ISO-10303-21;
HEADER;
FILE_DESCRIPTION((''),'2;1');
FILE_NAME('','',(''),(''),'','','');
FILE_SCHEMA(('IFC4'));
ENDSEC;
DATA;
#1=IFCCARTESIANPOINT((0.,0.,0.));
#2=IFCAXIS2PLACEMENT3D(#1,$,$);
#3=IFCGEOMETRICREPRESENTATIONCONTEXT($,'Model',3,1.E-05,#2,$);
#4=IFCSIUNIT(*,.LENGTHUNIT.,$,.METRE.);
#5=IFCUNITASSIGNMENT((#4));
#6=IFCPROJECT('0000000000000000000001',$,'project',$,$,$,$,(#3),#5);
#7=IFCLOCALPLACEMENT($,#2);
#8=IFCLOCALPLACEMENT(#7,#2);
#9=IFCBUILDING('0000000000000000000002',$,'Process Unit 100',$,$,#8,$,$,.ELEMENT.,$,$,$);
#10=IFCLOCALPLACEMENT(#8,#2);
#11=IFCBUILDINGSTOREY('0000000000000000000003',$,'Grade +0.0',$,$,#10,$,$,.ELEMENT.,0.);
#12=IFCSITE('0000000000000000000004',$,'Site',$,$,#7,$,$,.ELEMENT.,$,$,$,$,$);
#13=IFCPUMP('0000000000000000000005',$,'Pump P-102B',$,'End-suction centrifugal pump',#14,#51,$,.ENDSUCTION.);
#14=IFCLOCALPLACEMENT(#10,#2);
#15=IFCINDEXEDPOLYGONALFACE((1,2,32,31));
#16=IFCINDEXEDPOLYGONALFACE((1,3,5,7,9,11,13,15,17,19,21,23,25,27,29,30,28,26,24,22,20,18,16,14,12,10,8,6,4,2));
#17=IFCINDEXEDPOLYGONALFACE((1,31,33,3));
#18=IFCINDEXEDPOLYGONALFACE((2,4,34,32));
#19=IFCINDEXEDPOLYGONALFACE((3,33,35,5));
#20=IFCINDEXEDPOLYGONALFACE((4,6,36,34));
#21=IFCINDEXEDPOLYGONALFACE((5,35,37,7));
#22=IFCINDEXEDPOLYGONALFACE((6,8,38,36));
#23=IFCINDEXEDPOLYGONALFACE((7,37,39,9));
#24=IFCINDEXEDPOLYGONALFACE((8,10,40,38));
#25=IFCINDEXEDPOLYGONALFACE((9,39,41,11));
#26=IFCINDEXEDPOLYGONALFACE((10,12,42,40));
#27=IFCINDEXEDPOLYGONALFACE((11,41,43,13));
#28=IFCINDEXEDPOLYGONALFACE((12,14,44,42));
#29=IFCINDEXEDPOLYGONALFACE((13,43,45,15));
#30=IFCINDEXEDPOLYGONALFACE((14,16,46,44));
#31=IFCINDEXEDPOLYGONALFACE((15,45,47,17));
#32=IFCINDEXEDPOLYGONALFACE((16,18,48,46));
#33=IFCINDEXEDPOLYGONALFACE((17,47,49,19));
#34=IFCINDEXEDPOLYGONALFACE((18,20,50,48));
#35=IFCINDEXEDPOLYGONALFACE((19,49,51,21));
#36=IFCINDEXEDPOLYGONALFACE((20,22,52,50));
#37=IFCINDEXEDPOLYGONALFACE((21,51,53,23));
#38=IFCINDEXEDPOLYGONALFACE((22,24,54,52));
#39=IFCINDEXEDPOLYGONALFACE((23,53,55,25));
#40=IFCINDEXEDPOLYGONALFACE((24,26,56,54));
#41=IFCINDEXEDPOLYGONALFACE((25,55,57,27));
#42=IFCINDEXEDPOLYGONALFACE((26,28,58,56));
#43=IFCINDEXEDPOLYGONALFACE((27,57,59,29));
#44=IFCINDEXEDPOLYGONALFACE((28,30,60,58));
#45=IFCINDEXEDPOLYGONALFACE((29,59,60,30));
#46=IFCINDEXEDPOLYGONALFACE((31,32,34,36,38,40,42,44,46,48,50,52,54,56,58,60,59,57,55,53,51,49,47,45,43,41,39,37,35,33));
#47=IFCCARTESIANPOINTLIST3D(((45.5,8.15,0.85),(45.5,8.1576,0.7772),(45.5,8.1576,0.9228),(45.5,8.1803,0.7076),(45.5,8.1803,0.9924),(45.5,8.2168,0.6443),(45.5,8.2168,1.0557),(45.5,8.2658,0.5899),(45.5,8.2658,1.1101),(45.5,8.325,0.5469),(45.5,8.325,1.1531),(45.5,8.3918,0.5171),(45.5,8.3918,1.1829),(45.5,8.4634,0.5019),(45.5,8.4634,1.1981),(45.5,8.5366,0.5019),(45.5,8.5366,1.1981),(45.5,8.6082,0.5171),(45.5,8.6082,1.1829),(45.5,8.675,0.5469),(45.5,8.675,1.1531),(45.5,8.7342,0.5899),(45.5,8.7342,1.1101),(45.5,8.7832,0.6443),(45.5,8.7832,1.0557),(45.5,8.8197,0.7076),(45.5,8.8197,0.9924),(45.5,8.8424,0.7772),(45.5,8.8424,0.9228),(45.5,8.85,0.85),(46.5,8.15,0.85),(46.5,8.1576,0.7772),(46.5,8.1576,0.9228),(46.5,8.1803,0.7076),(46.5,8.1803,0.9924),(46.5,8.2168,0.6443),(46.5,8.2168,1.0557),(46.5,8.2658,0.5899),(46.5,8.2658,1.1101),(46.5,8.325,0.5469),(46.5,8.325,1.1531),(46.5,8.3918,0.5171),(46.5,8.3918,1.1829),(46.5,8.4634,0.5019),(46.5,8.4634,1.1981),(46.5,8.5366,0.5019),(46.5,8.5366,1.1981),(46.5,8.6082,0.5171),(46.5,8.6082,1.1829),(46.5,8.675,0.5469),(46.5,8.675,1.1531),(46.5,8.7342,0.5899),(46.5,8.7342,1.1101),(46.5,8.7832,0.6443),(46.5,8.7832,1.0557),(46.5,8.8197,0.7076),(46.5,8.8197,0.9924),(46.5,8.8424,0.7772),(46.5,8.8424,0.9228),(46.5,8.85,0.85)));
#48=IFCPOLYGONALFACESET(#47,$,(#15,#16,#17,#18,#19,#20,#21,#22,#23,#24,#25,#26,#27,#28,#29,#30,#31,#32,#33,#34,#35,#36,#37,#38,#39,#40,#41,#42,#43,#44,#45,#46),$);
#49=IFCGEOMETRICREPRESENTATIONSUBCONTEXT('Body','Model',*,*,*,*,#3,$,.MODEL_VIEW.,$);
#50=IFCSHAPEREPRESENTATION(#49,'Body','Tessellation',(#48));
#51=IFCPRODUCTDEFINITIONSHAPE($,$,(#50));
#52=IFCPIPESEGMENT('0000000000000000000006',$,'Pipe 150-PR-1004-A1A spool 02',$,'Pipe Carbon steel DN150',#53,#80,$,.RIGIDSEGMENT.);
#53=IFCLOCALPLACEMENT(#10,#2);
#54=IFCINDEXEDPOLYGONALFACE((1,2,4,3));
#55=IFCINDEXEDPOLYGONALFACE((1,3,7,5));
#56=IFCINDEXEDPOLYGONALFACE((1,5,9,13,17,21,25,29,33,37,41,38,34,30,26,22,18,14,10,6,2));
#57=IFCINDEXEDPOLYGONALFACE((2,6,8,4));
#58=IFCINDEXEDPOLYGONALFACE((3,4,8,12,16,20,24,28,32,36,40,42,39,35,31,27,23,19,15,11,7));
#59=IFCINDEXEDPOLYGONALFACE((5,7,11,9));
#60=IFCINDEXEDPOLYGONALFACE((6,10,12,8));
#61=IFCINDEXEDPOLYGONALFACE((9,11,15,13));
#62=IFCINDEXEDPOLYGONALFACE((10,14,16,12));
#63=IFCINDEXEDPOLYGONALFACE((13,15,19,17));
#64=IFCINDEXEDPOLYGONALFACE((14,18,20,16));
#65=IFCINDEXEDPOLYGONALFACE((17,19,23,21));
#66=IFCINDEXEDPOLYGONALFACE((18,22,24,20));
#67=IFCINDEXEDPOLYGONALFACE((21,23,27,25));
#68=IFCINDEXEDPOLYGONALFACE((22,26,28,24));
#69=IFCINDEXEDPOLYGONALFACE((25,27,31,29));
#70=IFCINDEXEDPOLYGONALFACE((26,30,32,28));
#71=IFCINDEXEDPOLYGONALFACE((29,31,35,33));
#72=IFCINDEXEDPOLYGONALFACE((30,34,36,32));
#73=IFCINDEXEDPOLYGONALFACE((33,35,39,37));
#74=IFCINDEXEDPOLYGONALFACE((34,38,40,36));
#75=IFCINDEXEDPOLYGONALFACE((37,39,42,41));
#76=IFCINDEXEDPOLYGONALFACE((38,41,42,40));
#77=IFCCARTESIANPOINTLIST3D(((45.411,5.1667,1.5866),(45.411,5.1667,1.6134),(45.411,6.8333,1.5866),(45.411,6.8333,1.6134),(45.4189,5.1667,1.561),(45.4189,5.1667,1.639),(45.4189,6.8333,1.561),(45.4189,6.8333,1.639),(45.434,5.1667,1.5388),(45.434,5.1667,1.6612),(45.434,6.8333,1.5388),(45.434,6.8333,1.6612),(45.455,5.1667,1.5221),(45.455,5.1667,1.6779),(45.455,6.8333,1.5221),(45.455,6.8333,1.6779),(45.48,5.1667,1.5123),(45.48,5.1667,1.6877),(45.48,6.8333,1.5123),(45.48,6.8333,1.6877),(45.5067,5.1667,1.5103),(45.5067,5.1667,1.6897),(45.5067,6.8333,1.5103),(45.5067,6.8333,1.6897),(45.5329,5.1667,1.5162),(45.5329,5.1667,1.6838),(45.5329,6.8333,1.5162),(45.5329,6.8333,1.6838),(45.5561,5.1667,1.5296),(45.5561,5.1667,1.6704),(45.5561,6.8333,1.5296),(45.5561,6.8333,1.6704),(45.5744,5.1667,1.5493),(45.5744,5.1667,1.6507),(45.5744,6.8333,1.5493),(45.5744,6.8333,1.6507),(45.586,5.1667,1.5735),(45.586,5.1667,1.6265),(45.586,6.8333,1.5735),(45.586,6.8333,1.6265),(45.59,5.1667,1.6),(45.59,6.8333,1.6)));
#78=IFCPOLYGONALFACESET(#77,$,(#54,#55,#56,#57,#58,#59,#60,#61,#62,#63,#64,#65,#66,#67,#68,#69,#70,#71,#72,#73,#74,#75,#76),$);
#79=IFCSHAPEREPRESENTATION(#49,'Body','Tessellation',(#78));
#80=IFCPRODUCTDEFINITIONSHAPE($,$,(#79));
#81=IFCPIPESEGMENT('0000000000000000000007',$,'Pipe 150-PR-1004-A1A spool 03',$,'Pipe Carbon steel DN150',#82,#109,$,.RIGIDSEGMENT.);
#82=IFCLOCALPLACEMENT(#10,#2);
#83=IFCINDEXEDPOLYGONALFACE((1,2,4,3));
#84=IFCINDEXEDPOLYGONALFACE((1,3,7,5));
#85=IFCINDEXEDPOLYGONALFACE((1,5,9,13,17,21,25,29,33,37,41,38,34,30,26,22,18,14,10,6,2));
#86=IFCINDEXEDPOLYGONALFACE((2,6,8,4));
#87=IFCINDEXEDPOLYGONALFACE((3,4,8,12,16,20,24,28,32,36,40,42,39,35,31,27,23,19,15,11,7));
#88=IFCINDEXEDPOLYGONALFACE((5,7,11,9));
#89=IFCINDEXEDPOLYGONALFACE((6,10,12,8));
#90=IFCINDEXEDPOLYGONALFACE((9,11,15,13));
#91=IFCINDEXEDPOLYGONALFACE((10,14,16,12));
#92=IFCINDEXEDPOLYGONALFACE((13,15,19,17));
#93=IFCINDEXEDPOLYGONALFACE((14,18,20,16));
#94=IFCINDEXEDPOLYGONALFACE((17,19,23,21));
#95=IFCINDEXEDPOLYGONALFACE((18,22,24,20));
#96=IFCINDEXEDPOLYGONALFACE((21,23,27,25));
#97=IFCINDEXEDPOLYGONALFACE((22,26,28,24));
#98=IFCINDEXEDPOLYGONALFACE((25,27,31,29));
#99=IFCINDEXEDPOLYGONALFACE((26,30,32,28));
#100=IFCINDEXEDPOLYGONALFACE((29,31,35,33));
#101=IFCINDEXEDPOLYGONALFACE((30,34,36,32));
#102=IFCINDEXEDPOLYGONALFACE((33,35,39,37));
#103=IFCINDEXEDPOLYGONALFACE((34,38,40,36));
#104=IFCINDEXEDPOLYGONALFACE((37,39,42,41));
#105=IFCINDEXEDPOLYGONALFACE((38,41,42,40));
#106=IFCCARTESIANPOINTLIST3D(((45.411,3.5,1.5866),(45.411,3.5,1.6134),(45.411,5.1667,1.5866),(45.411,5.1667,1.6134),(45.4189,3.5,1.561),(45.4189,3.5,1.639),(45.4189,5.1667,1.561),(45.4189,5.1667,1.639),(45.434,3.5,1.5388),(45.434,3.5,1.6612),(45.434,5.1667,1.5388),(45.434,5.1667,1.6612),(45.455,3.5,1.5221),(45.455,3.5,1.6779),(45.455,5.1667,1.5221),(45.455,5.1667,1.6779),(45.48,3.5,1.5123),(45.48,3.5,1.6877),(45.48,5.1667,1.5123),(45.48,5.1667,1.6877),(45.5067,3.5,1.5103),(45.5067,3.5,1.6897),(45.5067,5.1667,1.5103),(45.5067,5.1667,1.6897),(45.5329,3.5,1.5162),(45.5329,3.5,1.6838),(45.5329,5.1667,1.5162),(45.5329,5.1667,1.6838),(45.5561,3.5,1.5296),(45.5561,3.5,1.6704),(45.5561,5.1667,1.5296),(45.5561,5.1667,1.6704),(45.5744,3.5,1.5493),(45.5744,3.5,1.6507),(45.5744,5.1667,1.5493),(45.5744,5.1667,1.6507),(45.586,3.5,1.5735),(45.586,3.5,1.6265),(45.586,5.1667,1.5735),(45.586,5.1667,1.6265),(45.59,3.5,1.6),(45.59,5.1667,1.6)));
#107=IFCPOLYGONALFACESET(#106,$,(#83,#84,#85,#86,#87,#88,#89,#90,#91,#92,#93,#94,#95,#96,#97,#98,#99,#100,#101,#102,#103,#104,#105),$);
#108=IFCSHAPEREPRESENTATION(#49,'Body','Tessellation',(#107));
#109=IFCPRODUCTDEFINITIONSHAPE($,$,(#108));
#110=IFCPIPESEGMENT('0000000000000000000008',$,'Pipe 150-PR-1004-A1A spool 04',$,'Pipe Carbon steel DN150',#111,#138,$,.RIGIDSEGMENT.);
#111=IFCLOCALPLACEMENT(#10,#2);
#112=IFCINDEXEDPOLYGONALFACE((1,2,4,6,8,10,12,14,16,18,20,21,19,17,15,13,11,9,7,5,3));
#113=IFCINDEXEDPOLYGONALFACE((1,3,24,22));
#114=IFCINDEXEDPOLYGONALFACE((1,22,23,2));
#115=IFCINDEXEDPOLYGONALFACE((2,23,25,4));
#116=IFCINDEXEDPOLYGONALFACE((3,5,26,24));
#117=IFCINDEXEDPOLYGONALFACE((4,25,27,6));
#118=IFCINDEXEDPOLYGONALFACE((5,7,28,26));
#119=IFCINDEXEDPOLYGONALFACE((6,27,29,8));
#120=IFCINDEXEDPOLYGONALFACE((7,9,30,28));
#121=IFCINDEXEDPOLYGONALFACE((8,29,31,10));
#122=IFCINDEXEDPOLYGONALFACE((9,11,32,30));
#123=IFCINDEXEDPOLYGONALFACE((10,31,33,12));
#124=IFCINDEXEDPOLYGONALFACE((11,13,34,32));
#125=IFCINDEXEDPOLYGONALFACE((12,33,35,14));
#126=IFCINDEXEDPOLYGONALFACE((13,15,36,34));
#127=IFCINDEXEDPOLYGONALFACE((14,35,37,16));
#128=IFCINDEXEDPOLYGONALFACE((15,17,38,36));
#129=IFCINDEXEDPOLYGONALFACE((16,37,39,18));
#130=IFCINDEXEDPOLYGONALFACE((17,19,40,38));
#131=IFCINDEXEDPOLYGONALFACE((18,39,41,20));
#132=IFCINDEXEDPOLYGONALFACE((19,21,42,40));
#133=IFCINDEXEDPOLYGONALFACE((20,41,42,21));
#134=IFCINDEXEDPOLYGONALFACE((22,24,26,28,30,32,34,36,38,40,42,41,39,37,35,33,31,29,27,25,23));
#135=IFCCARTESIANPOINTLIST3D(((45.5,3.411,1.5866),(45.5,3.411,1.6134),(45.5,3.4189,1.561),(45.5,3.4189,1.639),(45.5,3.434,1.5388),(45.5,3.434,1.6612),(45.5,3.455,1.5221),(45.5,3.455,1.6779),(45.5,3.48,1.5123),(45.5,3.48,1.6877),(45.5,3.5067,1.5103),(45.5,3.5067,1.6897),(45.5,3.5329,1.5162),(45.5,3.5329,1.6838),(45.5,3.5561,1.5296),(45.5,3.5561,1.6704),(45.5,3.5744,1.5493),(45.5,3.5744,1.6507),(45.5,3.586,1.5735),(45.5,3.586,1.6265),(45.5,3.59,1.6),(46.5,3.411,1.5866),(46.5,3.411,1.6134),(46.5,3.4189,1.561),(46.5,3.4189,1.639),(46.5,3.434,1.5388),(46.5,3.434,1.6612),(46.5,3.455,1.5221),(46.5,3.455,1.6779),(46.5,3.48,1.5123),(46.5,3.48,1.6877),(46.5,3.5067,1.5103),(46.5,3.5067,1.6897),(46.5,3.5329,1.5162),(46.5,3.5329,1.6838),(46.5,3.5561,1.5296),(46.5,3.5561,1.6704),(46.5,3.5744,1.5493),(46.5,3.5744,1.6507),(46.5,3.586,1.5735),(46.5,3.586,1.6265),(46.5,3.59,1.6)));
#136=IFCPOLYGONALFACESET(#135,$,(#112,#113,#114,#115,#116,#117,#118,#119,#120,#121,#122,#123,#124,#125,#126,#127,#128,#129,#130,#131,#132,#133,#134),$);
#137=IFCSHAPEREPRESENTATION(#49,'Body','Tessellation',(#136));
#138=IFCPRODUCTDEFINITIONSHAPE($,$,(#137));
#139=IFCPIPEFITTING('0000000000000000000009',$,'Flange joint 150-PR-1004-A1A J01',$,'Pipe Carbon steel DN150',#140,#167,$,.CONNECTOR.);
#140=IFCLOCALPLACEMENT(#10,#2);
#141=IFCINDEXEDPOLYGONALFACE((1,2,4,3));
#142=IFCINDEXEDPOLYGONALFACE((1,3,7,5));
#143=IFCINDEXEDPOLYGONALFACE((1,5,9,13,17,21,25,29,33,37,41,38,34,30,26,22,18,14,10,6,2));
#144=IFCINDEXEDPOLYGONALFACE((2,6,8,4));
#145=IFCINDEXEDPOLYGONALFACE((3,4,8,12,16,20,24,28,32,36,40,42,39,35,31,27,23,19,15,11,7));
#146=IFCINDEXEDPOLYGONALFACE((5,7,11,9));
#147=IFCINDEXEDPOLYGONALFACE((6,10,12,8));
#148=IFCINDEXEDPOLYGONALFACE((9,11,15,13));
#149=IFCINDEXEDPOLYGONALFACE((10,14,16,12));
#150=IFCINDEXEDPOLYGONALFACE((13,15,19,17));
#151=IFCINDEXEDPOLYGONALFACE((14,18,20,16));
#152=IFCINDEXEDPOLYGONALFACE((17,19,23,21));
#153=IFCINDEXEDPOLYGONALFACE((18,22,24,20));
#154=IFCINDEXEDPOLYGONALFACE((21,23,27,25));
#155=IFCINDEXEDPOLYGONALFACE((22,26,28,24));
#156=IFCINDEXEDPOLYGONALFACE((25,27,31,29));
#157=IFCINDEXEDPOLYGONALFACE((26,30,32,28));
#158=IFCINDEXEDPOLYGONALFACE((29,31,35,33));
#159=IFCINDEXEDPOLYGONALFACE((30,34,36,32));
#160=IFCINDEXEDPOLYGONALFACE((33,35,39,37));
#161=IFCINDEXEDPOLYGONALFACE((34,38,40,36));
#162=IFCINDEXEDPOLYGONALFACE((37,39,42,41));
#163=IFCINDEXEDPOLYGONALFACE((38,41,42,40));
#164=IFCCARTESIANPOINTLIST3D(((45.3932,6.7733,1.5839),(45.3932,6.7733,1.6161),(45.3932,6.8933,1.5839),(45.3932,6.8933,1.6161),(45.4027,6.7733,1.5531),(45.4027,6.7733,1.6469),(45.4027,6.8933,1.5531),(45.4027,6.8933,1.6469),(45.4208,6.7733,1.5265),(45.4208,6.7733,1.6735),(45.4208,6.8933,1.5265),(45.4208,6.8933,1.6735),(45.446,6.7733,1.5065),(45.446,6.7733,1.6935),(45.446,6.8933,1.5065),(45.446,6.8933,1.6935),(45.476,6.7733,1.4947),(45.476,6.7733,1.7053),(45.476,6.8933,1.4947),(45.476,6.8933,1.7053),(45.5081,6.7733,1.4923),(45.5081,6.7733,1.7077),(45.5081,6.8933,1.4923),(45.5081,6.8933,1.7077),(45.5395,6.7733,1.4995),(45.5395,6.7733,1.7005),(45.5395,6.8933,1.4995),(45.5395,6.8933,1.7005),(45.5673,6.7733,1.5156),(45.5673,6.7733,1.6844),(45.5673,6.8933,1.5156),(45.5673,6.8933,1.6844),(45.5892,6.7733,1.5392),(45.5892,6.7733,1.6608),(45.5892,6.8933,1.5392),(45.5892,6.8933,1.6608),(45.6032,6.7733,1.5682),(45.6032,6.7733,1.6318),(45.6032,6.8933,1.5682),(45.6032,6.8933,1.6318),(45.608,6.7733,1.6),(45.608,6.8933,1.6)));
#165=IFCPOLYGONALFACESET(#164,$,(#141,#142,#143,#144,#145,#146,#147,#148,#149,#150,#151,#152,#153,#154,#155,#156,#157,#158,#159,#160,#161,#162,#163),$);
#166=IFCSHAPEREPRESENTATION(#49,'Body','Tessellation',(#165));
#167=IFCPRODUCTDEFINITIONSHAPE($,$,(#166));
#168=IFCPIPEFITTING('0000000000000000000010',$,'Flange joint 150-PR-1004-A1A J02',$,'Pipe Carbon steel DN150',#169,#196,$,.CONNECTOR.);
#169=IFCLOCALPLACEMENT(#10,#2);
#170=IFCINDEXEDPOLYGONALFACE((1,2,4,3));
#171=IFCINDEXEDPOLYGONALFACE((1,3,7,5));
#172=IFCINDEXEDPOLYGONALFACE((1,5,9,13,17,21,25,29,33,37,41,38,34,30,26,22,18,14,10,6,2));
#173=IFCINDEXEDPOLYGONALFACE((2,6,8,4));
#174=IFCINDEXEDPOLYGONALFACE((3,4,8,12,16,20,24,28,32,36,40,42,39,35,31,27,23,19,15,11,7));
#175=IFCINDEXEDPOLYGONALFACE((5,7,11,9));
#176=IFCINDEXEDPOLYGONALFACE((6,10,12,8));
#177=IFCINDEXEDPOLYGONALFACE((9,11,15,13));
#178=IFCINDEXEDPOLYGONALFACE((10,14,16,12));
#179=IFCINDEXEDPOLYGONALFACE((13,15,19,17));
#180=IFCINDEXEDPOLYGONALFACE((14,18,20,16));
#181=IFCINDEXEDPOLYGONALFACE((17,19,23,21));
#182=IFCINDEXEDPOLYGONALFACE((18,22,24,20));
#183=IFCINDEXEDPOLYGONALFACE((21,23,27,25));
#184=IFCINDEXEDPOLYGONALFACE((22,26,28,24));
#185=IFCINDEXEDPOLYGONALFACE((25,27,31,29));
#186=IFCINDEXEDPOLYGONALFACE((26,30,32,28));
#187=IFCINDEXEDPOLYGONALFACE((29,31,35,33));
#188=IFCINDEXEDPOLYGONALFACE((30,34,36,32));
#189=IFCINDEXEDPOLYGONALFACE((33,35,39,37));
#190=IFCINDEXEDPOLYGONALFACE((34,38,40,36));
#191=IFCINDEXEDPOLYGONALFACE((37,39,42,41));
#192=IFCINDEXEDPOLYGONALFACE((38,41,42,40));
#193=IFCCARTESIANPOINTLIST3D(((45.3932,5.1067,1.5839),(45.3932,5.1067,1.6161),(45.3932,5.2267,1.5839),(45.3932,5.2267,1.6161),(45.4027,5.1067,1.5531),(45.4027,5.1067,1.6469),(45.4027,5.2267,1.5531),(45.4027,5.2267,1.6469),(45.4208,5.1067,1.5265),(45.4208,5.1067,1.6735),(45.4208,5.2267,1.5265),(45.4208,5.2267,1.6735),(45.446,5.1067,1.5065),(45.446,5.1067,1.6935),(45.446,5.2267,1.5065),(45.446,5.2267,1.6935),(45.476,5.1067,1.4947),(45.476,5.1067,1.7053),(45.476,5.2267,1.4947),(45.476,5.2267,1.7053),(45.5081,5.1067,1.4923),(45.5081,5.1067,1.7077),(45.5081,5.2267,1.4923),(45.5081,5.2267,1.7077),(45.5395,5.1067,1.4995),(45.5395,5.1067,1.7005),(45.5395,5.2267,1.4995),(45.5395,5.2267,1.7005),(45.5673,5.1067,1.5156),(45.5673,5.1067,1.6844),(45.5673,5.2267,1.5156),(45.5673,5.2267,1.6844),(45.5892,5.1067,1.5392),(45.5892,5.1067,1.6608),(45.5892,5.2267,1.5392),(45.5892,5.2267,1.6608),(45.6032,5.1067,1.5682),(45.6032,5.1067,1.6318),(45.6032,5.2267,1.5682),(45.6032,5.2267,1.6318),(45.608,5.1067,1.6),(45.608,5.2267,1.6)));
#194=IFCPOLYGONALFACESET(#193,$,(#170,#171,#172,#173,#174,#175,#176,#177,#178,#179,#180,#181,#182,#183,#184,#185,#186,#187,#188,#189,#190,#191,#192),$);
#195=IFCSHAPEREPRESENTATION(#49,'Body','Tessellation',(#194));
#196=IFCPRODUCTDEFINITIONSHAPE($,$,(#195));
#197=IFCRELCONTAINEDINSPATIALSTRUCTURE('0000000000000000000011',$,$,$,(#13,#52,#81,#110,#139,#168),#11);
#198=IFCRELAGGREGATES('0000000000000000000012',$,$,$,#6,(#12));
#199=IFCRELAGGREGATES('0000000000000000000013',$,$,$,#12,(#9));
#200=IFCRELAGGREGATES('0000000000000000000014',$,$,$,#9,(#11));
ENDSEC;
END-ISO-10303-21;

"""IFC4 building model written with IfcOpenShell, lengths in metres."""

from ifc_helpers import new_model, si_unit, frame, origin, place, context, subcontext, project, spatial, circle, extrude, element, save


model = new_model("IFC4")

# Units and contexts
model_context = context("Model", 3, precision=1e-05, world=origin())
body_context = subcontext(model_context, "Body", "Model", "MODEL_VIEW")
ifc_project = project(units=[si_unit("LENGTHUNIT", "METRE")], contexts=[model_context])

# Site, building, storey
site_placement = place(None, origin())
site = spatial("IfcSite", under=ifc_project, at=site_placement, Name="Site", CompositionType="ELEMENT")
building_placement = place(site_placement, origin())
building = spatial("IfcBuilding", under=site, at=building_placement, Name="Process Unit 100", CompositionType="ELEMENT")
storey_placement = place(building_placement, origin())
storey = spatial("IfcBuildingStorey", under=building, at=storey_placement, Name="Grade +0.0", CompositionType="ELEMENT", Elevation=0.0)

# Pump
pump_1_placement = place(storey_placement, frame((45.5, 8.5, 0.85), z_axis=(1.0, 0.0, 0.0), x_axis=(0.0, 1.0, 0.0)))
element("IfcPump", 1, at=pump_1_placement, inside=storey, Name="Pump P-102B", ObjectType="End-suction centrifugal pump", PredefinedType="ENDSUCTION", context=body_context, shape_type="SweptSolid", body=[
    extrude(circle(Radius=0.35), origin(), (0.0, 0.0, 1.0), 1.0),
])

# Pipe segments
for number, where, z_axis, x_axis, name in (
    (2, (45.5, 6.8333, 1.6), (0.0, -1.0, 0.0), (1.0, 0.0, 0.0), "Pipe 150-PR-1004-A1A spool 02"),
    (3, (45.5, 5.1667, 1.6), (0.0, -1.0, 0.0), (1.0, 0.0, 0.0), "Pipe 150-PR-1004-A1A spool 03"),
):
    element("IfcPipeSegment", number, at=place(storey_placement, frame(where, z_axis=z_axis, x_axis=x_axis)), inside=storey, Name=name, ObjectType="Pipe Carbon steel DN150", PredefinedType="RIGIDSEGMENT", context=body_context, shape_type="SweptSolid", body=[
        extrude(circle(Radius=0.09), origin(), (0.0, 0.0, 1.0), 1.6667),
    ])
pipe_segment_1_placement = place(storey_placement, frame((45.5, 3.5, 1.6), z_axis=(1.0, 0.0, 0.0), x_axis=(0.0, 1.0, 0.0)))
element("IfcPipeSegment", 4, at=pipe_segment_1_placement, inside=storey, Name="Pipe 150-PR-1004-A1A spool 04", ObjectType="Pipe Carbon steel DN150", PredefinedType="RIGIDSEGMENT", context=body_context, shape_type="SweptSolid", body=[
    extrude(circle(Radius=0.09), origin(), (0.0, 0.0, 1.0), 1.0),
])

# Pipe fittings
for number, where, z_axis, x_axis, name in (
    (5, (45.5, 6.8933, 1.6), (0.0, -1.0, 0.0), (1.0, 0.0, 0.0), "Flange joint 150-PR-1004-A1A J01"),
    (6, (45.5, 5.2267, 1.6), (0.0, -1.0, 0.0), (1.0, 0.0, 0.0), "Flange joint 150-PR-1004-A1A J02"),
):
    element("IfcPipeFitting", number, at=place(storey_placement, frame(where, z_axis=z_axis, x_axis=x_axis)), inside=storey, Name=name, ObjectType="Pipe Carbon steel DN150", PredefinedType="CONNECTOR", context=body_context, shape_type="SweptSolid", body=[
        extrude(circle(Radius=0.108), origin(), (0.0, 0.0, 1.0), 0.12),
    ])

save(model, "model.ifc")
